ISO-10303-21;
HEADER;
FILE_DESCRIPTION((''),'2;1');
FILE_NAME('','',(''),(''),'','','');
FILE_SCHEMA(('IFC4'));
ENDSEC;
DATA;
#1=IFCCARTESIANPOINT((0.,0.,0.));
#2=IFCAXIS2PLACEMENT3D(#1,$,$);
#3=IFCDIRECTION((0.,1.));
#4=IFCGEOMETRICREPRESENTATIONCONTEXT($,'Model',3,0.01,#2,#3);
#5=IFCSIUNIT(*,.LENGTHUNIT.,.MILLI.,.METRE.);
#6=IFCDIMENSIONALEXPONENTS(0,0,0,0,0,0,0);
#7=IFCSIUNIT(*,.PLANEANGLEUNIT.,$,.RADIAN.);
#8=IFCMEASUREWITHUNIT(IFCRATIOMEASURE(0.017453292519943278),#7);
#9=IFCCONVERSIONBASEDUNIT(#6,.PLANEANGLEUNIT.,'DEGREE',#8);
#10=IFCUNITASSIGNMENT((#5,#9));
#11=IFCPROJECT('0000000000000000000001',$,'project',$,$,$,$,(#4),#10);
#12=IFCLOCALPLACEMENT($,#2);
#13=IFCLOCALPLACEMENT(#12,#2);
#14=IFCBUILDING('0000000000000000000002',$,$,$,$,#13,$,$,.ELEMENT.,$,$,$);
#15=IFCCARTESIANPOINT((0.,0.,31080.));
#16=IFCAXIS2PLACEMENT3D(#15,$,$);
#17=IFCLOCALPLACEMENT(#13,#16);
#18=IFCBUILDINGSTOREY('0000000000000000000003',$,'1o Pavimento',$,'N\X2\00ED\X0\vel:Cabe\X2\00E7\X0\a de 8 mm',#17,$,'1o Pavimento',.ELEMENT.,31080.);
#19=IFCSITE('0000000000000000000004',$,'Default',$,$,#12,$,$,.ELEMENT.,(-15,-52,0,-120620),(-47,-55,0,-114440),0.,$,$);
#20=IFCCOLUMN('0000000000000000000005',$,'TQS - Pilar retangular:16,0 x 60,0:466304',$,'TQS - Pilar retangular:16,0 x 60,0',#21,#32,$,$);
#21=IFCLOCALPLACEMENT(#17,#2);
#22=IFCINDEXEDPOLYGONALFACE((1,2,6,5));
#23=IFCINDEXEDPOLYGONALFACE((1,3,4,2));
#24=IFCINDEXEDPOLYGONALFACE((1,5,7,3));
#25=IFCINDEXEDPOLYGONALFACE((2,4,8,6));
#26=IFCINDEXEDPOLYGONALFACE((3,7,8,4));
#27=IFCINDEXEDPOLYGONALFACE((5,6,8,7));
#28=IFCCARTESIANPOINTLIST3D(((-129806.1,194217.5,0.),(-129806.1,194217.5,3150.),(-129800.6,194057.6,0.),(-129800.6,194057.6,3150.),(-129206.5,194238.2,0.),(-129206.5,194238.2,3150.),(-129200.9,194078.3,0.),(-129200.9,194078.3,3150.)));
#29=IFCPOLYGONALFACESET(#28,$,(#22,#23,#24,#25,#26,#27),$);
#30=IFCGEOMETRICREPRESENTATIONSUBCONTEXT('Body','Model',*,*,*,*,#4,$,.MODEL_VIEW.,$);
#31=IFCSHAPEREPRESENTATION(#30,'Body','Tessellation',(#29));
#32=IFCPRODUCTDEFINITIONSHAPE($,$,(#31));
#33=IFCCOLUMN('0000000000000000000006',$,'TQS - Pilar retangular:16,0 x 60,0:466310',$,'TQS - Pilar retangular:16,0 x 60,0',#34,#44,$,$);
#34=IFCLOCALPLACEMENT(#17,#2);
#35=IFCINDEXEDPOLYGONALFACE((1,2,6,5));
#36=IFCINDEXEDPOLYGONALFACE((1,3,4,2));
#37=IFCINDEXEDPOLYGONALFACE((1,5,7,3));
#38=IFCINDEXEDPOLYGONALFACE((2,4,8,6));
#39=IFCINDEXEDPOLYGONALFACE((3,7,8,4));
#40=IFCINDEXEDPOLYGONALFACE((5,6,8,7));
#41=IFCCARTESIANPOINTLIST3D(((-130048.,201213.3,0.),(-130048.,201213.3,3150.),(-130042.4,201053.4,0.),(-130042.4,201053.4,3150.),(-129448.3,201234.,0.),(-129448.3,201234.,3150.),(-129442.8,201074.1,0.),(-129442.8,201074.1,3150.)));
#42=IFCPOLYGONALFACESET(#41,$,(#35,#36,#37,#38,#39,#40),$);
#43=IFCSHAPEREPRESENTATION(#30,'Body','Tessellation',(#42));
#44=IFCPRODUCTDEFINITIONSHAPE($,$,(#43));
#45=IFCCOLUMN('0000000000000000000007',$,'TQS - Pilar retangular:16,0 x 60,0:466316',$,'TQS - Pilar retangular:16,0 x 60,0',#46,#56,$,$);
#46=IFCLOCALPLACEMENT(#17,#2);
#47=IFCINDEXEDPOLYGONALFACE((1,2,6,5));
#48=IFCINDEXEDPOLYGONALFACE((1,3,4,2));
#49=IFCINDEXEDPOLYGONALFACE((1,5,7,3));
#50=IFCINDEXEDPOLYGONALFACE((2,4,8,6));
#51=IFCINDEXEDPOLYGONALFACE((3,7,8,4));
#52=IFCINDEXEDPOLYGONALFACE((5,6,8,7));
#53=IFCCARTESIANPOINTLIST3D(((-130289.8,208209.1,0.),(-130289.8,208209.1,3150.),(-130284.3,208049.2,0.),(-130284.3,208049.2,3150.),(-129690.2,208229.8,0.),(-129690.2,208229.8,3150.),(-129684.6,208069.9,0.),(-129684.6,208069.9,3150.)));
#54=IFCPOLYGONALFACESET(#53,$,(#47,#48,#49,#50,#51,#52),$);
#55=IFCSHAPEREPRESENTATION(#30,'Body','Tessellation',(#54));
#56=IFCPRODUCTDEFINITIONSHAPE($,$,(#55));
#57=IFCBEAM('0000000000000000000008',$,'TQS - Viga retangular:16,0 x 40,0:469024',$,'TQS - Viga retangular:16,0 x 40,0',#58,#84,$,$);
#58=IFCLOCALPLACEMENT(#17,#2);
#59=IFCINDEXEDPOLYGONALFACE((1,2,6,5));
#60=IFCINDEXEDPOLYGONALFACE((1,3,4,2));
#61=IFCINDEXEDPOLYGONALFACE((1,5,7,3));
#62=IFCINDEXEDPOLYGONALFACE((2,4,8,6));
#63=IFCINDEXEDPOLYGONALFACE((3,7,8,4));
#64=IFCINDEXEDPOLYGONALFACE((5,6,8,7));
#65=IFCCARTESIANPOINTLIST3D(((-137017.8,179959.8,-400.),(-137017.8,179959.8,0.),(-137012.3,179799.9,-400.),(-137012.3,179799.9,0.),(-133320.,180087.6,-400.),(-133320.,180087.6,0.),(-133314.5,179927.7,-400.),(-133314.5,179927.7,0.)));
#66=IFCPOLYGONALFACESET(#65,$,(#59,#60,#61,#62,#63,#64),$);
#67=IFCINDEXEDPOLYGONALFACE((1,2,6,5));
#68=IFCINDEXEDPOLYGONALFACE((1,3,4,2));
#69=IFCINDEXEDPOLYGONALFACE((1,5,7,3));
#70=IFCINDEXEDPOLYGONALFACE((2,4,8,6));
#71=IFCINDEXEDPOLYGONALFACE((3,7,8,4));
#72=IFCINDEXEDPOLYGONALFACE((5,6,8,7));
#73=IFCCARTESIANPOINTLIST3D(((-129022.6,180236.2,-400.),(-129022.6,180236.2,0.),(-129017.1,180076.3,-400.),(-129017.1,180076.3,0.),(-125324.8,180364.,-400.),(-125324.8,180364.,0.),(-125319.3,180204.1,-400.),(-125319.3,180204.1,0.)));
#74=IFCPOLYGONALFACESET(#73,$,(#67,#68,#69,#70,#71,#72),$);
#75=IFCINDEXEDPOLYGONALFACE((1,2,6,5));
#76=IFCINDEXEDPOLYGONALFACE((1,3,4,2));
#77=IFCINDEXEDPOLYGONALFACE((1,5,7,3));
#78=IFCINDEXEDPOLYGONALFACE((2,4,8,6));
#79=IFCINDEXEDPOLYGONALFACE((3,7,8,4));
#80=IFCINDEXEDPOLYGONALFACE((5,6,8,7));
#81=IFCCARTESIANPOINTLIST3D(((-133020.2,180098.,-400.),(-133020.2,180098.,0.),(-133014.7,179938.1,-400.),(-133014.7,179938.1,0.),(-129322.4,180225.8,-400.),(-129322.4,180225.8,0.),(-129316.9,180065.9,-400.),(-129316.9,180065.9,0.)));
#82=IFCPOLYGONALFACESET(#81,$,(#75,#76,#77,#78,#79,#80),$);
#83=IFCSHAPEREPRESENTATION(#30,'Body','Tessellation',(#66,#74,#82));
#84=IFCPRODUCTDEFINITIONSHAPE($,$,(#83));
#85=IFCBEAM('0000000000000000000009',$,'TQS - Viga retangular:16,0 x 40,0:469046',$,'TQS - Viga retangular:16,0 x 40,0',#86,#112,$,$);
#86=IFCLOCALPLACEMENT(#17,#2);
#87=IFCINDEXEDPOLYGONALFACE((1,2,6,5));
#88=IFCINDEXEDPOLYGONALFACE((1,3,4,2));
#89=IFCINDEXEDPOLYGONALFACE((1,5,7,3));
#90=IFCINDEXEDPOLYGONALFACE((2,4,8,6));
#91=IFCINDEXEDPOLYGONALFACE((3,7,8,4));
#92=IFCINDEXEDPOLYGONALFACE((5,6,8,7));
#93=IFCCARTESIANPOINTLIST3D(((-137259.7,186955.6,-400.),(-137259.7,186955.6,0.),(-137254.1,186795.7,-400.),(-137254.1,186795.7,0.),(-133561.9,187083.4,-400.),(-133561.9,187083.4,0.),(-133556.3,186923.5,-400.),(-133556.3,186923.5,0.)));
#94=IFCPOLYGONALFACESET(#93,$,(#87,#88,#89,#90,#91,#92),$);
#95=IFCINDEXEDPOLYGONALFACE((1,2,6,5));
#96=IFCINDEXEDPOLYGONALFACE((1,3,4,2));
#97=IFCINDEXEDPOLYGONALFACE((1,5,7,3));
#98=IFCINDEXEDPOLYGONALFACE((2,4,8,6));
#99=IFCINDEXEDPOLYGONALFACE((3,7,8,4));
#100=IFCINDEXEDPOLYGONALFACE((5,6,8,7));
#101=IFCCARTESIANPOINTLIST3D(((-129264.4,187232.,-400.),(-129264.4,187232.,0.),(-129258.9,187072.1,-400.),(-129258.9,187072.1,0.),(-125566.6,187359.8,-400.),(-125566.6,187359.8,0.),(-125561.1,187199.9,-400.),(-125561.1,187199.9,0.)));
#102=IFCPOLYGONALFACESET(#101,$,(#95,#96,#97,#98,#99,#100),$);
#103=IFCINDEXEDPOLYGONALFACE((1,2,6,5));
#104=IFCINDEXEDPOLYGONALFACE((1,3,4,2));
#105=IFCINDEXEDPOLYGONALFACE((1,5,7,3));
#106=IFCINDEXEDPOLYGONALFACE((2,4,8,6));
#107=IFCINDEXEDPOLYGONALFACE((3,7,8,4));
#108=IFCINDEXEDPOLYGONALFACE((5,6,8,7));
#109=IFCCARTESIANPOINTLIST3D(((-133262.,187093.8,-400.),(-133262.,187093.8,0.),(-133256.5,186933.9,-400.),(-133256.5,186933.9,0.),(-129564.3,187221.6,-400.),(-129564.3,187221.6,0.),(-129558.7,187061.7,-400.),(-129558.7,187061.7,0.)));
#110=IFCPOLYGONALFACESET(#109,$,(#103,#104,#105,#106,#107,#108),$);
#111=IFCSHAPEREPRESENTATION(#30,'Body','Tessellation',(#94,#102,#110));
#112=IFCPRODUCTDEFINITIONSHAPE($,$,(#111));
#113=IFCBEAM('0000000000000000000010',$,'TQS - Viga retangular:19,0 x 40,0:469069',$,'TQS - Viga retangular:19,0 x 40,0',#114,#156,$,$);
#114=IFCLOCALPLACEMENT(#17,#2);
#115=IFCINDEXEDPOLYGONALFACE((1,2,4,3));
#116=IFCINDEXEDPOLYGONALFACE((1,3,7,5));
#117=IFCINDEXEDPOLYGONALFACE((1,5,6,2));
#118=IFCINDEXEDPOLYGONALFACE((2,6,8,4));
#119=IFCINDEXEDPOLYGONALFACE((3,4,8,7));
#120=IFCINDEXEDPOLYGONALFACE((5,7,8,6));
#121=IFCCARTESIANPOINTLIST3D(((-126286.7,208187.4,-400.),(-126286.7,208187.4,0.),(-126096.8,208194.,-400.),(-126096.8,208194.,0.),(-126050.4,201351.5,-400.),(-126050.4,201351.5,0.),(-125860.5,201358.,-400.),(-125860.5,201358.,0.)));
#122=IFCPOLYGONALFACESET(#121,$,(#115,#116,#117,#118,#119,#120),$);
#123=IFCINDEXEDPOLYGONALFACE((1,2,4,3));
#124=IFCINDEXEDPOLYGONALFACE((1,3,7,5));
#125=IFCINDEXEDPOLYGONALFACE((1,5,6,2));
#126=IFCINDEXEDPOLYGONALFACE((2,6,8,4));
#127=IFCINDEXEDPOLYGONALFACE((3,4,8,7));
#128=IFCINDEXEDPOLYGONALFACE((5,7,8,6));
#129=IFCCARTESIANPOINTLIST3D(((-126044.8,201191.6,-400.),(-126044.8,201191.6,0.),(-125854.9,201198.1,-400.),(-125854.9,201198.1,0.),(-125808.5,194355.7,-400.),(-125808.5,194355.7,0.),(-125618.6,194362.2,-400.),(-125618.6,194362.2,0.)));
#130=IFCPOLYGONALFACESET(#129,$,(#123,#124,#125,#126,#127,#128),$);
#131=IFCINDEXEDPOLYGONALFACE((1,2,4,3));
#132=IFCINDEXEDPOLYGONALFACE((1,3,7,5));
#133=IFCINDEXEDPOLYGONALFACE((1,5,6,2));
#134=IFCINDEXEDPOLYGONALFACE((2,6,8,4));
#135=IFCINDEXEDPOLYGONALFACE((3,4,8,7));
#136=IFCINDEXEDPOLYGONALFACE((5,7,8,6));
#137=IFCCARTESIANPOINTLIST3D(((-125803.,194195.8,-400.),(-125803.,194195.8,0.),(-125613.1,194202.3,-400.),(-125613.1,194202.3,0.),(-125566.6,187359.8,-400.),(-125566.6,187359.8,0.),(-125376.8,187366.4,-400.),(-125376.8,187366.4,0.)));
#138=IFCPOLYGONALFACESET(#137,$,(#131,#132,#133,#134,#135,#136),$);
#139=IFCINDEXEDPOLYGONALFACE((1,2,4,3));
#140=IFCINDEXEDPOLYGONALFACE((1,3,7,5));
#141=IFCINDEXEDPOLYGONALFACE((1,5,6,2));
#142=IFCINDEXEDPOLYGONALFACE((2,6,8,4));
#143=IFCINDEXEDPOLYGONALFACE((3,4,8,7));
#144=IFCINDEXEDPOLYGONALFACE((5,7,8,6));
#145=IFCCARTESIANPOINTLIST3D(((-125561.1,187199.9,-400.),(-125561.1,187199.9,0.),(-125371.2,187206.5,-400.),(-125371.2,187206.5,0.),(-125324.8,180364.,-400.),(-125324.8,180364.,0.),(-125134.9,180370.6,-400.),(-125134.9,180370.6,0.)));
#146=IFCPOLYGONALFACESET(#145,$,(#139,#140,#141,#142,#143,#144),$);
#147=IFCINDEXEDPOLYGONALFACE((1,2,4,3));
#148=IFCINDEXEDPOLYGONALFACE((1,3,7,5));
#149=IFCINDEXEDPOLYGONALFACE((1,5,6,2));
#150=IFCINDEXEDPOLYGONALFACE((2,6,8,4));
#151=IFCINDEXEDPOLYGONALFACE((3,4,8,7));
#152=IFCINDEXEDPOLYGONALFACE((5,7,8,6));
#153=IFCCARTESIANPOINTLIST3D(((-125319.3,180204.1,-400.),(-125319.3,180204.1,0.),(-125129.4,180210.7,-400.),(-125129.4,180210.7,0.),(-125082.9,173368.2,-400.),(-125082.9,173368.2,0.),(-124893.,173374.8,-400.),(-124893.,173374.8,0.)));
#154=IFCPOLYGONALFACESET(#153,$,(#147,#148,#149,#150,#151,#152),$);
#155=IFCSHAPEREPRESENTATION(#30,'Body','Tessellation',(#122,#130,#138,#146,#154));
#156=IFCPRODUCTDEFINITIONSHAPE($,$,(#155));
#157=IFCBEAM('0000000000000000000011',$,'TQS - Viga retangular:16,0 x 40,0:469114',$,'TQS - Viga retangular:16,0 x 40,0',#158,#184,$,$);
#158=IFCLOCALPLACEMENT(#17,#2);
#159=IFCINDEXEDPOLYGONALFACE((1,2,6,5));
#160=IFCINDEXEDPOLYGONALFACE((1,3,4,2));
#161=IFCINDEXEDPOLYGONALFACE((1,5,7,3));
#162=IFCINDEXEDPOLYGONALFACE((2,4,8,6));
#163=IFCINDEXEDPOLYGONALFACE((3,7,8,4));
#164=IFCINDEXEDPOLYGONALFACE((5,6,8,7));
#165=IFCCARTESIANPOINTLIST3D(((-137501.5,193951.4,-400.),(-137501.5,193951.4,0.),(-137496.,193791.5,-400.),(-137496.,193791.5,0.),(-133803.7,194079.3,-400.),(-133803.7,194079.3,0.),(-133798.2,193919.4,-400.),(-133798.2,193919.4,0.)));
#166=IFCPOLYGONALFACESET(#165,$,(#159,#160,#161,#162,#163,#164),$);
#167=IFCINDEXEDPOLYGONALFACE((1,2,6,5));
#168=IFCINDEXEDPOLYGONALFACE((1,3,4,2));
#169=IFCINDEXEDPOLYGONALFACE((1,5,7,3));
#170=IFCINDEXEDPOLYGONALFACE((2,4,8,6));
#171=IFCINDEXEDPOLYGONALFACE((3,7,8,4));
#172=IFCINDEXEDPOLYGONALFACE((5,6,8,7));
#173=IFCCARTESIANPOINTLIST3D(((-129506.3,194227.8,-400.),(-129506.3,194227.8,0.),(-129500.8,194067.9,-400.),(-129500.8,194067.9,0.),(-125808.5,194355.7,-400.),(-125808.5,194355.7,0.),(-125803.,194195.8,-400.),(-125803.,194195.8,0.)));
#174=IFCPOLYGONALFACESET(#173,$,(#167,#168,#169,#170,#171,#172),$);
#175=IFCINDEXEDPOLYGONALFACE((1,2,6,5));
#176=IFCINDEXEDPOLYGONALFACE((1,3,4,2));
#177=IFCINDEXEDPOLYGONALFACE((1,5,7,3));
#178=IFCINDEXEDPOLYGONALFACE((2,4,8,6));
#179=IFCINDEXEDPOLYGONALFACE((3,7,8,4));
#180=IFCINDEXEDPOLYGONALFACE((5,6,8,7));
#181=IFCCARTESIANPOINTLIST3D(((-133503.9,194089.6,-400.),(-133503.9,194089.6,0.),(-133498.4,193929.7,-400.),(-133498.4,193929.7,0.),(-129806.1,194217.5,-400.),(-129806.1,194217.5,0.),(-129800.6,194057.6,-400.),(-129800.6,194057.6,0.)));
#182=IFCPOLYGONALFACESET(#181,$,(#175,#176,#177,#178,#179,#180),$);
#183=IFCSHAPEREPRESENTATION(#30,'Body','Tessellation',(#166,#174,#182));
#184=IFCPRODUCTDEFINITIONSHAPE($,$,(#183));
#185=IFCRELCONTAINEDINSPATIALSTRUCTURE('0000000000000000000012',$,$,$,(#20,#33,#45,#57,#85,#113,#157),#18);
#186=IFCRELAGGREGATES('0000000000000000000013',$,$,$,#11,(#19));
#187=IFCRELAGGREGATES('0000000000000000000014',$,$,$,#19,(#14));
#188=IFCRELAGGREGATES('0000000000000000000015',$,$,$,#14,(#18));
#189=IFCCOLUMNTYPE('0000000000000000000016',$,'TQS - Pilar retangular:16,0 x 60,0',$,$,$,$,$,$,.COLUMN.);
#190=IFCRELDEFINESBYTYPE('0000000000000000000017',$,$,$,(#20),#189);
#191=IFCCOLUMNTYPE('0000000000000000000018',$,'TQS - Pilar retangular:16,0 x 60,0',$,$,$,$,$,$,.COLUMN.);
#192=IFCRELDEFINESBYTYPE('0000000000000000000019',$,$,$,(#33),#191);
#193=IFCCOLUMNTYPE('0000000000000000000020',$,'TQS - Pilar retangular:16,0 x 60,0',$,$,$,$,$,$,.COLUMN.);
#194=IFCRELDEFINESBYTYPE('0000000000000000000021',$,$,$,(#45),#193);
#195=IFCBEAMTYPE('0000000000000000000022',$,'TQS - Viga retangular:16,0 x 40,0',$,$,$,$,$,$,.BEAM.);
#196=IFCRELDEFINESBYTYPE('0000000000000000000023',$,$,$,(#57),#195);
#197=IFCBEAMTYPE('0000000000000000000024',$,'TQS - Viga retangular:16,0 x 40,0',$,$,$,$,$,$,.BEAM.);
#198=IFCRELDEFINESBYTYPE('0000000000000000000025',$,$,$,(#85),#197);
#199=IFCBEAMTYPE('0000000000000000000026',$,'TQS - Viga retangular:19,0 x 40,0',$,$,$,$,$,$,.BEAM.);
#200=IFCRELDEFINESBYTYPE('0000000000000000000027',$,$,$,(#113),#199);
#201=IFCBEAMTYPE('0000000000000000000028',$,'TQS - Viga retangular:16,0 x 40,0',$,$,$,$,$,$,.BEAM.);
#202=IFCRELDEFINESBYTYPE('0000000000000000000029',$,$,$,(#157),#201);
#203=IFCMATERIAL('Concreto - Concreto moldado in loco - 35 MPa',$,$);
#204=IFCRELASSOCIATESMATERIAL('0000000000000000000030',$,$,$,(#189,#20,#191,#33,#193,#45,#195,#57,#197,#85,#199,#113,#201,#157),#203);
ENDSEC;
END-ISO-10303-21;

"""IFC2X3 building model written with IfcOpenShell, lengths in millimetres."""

from ifc_helpers import new_model, entity, si_unit, converted_unit, direction, frame, frame_2d, origin, origin_2d_with_axis, place, context, subcontext, project, spatial, rectangle, extrude, source, transform, mapped, material, type_object, type_shapes, element, save


model = new_model("IFC2X3")

# Units and contexts
model_context = context("Model", 3, precision=0.01, world=origin(), true_north=direction((0.0, 1.0)))
body_context = subcontext(model_context, "Body", "Model", "MODEL_VIEW")
ifc_project = project(units=[si_unit("LENGTHUNIT", "METRE", prefix="MILLI"), converted_unit("PLANEANGLEUNIT", "DEGREE", entity("IfcRatioMeasure", 0.017453292519943278), si_unit("PLANEANGLEUNIT", "RADIAN"), dimensions=[0, 0, 0, 0, 0, 0, 0])], contexts=[model_context])

# Site, building, storey
site_placement = place(None, origin())
site = spatial("IfcSite", under=ifc_project, at=site_placement, Name="Default", CompositionType="ELEMENT", RefLatitude=(-15, -52, 0, -120620), RefLongitude=(-47, -55, 0, -114440), RefElevation=0.0)
building_placement = place(site_placement, origin())
building = spatial("IfcBuilding", under=site, at=building_placement, CompositionType="ELEMENT")
storey_placement = place(building_placement, frame((0.0, 0.0, 31080.0)))
storey = spatial("IfcBuildingStorey", under=building, at=storey_placement, Name="1o Pavimento", ObjectType="Nível:Cabeça de 8 mm", LongName="1o Pavimento", CompositionType="ELEMENT", Elevation=31080.0)

# Columns
ifc_material = material(Name="Concreto - Concreto moldado in loco - 35 MPa")
column_type_1 = type_object("IfcColumnType", Name="TQS - Pilar retangular:16,0 x 60,0", PredefinedType="COLUMN", material=ifc_material)
shared_shape_1 = source(origin(), body_context, "Body", "SweptSolid", [
    extrude(rectangle(XDim=600.0, YDim=160.0, at=origin_2d_with_axis()), frame((-129503.5, 194147.9, 31080.0), z_axis=(0.0, 0.0, 1.0), x_axis=(-0.999403, -0.034551, 0.0)), (0.0, 0.0, 1.0), 3150.0),
])
type_shapes(column_type_1, [shared_shape_1])
column_1_placement = place(storey_placement, frame((0.0, 0.0, -31080.0)))
element("IfcColumn", 1, at=column_1_placement, inside=storey, type_object=column_type_1, material=ifc_material, Name="TQS - Pilar retangular:16,0 x 60,0:466304", ObjectType="TQS - Pilar retangular:16,0 x 60,0", context=body_context, shape_type="MappedRepresentation", body=[
    mapped(shared_shape_1, transform((0.0, 0.0, 0.0), scale=1.0)),
])
column_type_2 = type_object("IfcColumnType", Name="TQS - Pilar retangular:16,0 x 60,0", PredefinedType="COLUMN", material=ifc_material)
shared_shape_2 = source(origin(), body_context, "Body", "SweptSolid", [
    extrude(rectangle(XDim=600.0, YDim=160.0, at=origin_2d_with_axis()), frame((-129745.4, 201143.7, 31080.0), z_axis=(0.0, 0.0, 1.0), x_axis=(-0.999403, -0.034551, 0.0)), (0.0, 0.0, 1.0), 3150.0),
])
type_shapes(column_type_2, [shared_shape_2])
column_2_placement = place(storey_placement, frame((0.0, 0.0, -31080.0)))
element("IfcColumn", 2, at=column_2_placement, inside=storey, type_object=column_type_2, material=ifc_material, Name="TQS - Pilar retangular:16,0 x 60,0:466310", ObjectType="TQS - Pilar retangular:16,0 x 60,0", context=body_context, shape_type="MappedRepresentation", body=[
    mapped(shared_shape_2, transform((0.0, 0.0, 0.0), scale=1.0)),
])
column_type_3 = type_object("IfcColumnType", Name="TQS - Pilar retangular:16,0 x 60,0", PredefinedType="COLUMN", material=ifc_material)
shared_shape_3 = source(origin(), body_context, "Body", "SweptSolid", [
    extrude(rectangle(XDim=600.0, YDim=160.0, at=origin_2d_with_axis()), frame((-129987.2, 208139.5, 31080.0), z_axis=(0.0, 0.0, 1.0), x_axis=(-0.999403, -0.034551, 0.0)), (0.0, 0.0, 1.0), 3150.0),
])
type_shapes(column_type_3, [shared_shape_3])
column_3_placement = place(storey_placement, frame((0.0, 0.0, -31080.0)))
element("IfcColumn", 3, at=column_3_placement, inside=storey, type_object=column_type_3, material=ifc_material, Name="TQS - Pilar retangular:16,0 x 60,0:466316", ObjectType="TQS - Pilar retangular:16,0 x 60,0", context=body_context, shape_type="MappedRepresentation", body=[
    mapped(shared_shape_3, transform((0.0, 0.0, 0.0), scale=1.0)),
])

# Beams
beam_type_1 = type_object("IfcBeamType", Name="TQS - Viga retangular:16,0 x 40,0", PredefinedType="BEAM", material=ifc_material)
shared_shape_4 = source(origin(), body_context, "Body", "SweptSolid", [
    extrude(rectangle(XDim=400.0, YDim=160.0, at=frame_2d((0.0, 0.0), x_axis=(1.0, 0.0))), frame((-133317.2, 180007.7, 30880.0), z_axis=(-0.999403, -0.034551, 0.0), x_axis=(0.0, 0.0, -1.0)), (0.0, 0.0, 1.0), 3700.0),
    extrude(rectangle(XDim=400.0, YDim=160.0, at=frame_2d((0.0, 0.0), x_axis=(1.0, 0.0))), frame((-125322.0, 180284.1, 30880.0), z_axis=(-0.999403, -0.034551, 0.0), x_axis=(0.0, 0.0, -1.0)), (0.0, 0.0, 1.0), 3700.0),
    extrude(rectangle(XDim=400.0, YDim=160.0, at=frame_2d((0.0, 0.0), x_axis=(1.0, 0.0))), frame((-129319.6, 180145.9, 30880.0), z_axis=(-0.999403, -0.034551, 0.0), x_axis=(0.0, 0.0, -1.0)), (0.0, 0.0, 1.0), 3700.0),
])
type_shapes(beam_type_1, [shared_shape_4])
beam_1_placement = place(storey_placement, frame((0.0, 0.0, -31080.0)))
element("IfcBeam", 4, at=beam_1_placement, inside=storey, type_object=beam_type_1, material=ifc_material, Name="TQS - Viga retangular:16,0 x 40,0:469024", ObjectType="TQS - Viga retangular:16,0 x 40,0", context=body_context, shape_type="MappedRepresentation", body=[
    mapped(shared_shape_4, transform((0.0, 0.0, 0.0), scale=1.0)),
])
beam_type_2 = type_object("IfcBeamType", Name="TQS - Viga retangular:16,0 x 40,0", PredefinedType="BEAM", material=ifc_material)
shared_shape_5 = source(origin(), body_context, "Body", "SweptSolid", [
    extrude(rectangle(XDim=400.0, YDim=160.0, at=frame_2d((0.0, 0.0), x_axis=(1.0, 0.0))), frame((-133559.1, 187003.5, 30880.0), z_axis=(-0.999403, -0.034551, 0.0), x_axis=(0.0, 0.0, -1.0)), (0.0, 0.0, 1.0), 3700.0),
    extrude(rectangle(XDim=400.0, YDim=160.0, at=frame_2d((0.0, 0.0), x_axis=(1.0, 0.0))), frame((-125563.9, 187279.9, 30880.0), z_axis=(-0.999403, -0.034551, 0.0), x_axis=(0.0, 0.0, -1.0)), (0.0, 0.0, 1.0), 3700.0),
    extrude(rectangle(XDim=400.0, YDim=160.0, at=frame_2d((0.0, 0.0), x_axis=(1.0, 0.0))), frame((-129561.5, 187141.7, 30880.0), z_axis=(-0.999403, -0.034551, 0.0), x_axis=(0.0, 0.0, -1.0)), (0.0, 0.0, 1.0), 3700.0),
])
type_shapes(beam_type_2, [shared_shape_5])
beam_2_placement = place(storey_placement, frame((0.0, 0.0, -31080.0)))
element("IfcBeam", 5, at=beam_2_placement, inside=storey, type_object=beam_type_2, material=ifc_material, Name="TQS - Viga retangular:16,0 x 40,0:469046", ObjectType="TQS - Viga retangular:16,0 x 40,0", context=body_context, shape_type="MappedRepresentation", body=[
    mapped(shared_shape_5, transform((0.0, 0.0, 0.0), scale=1.0)),
])
beam_type_3 = type_object("IfcBeamType", Name="TQS - Viga retangular:19,0 x 40,0", PredefinedType="BEAM", material=ifc_material)
shared_shape_6 = source(origin(), body_context, "Body", "SweptSolid", [
    extrude(rectangle(XDim=400.0, YDim=190.0, at=frame_2d((0.0, 0.0), x_axis=(1.0, 0.0))), frame((-125955.4, 201354.8, 30880.0), z_axis=(-0.034551, 0.999403, 0.0), x_axis=(0.0, 0.0, 1.0)), (0.0, 0.0, 1.0), 6840.0),
    extrude(rectangle(XDim=400.0, YDim=190.0, at=frame_2d((0.0, 0.0), x_axis=(1.0, 0.0))), frame((-125713.6, 194358.9, 30880.0), z_axis=(-0.034551, 0.999403, 0.0), x_axis=(0.0, 0.0, 1.0)), (0.0, 0.0, 1.0), 6840.0),
    extrude(rectangle(XDim=400.0, YDim=190.0, at=frame_2d((0.0, 0.0), x_axis=(1.0, 0.0))), frame((-125471.7, 187363.1, 30880.0), z_axis=(-0.034551, 0.999403, 0.0), x_axis=(0.0, 0.0, 1.0)), (0.0, 0.0, 1.0), 6840.0),
    extrude(rectangle(XDim=400.0, YDim=190.0, at=frame_2d((0.0, 0.0), x_axis=(1.0, 0.0))), frame((-125229.8, 180367.3, 30880.0), z_axis=(-0.034551, 0.999403, 0.0), x_axis=(0.0, 0.0, 1.0)), (0.0, 0.0, 1.0), 6840.0),
    extrude(rectangle(XDim=400.0, YDim=190.0, at=frame_2d((0.0, 0.0), x_axis=(1.0, 0.0))), frame((-124988.0, 173371.5, 30880.0), z_axis=(-0.034551, 0.999403, 0.0), x_axis=(0.0, 0.0, 1.0)), (0.0, 0.0, 1.0), 6840.0),
])
type_shapes(beam_type_3, [shared_shape_6])
beam_3_placement = place(storey_placement, frame((0.0, 0.0, -31080.0)))
element("IfcBeam", 6, at=beam_3_placement, inside=storey, type_object=beam_type_3, material=ifc_material, Name="TQS - Viga retangular:19,0 x 40,0:469069", ObjectType="TQS - Viga retangular:19,0 x 40,0", context=body_context, shape_type="MappedRepresentation", body=[
    mapped(shared_shape_6, transform((0.0, 0.0, 0.0), scale=1.0)),
])
beam_type_4 = type_object("IfcBeamType", Name="TQS - Viga retangular:16,0 x 40,0", PredefinedType="BEAM", material=ifc_material)
shared_shape_7 = source(origin(), body_context, "Body", "SweptSolid", [
    extrude(rectangle(XDim=400.0, YDim=160.0, at=frame_2d((0.0, 0.0), x_axis=(1.0, 0.0))), frame((-133801.0, 193999.3, 30880.0), z_axis=(-0.999403, -0.034551, 0.0), x_axis=(0.0, 0.0, -1.0)), (0.0, 0.0, 1.0), 3700.0),
    extrude(rectangle(XDim=400.0, YDim=160.0, at=frame_2d((0.0, 0.0), x_axis=(1.0, 0.0))), frame((-125805.7, 194275.7, 30880.0), z_axis=(-0.999403, -0.034551, 0.0), x_axis=(0.0, 0.0, -1.0)), (0.0, 0.0, 1.0), 3700.0),
    extrude(rectangle(XDim=400.0, YDim=160.0, at=frame_2d((0.0, 0.0), x_axis=(1.0, 0.0))), frame((-129803.3, 194137.5, 30880.0), z_axis=(-0.999403, -0.034551, 0.0), x_axis=(0.0, 0.0, -1.0)), (0.0, 0.0, 1.0), 3700.0),
])
type_shapes(beam_type_4, [shared_shape_7])
beam_4_placement = place(storey_placement, frame((0.0, 0.0, -31080.0)))
element("IfcBeam", 7, at=beam_4_placement, inside=storey, type_object=beam_type_4, material=ifc_material, Name="TQS - Viga retangular:16,0 x 40,0:469114", ObjectType="TQS - Viga retangular:16,0 x 40,0", context=body_context, shape_type="MappedRepresentation", body=[
    mapped(shared_shape_7, transform((0.0, 0.0, 0.0), scale=1.0)),
])

save(model, "model.ifc")
